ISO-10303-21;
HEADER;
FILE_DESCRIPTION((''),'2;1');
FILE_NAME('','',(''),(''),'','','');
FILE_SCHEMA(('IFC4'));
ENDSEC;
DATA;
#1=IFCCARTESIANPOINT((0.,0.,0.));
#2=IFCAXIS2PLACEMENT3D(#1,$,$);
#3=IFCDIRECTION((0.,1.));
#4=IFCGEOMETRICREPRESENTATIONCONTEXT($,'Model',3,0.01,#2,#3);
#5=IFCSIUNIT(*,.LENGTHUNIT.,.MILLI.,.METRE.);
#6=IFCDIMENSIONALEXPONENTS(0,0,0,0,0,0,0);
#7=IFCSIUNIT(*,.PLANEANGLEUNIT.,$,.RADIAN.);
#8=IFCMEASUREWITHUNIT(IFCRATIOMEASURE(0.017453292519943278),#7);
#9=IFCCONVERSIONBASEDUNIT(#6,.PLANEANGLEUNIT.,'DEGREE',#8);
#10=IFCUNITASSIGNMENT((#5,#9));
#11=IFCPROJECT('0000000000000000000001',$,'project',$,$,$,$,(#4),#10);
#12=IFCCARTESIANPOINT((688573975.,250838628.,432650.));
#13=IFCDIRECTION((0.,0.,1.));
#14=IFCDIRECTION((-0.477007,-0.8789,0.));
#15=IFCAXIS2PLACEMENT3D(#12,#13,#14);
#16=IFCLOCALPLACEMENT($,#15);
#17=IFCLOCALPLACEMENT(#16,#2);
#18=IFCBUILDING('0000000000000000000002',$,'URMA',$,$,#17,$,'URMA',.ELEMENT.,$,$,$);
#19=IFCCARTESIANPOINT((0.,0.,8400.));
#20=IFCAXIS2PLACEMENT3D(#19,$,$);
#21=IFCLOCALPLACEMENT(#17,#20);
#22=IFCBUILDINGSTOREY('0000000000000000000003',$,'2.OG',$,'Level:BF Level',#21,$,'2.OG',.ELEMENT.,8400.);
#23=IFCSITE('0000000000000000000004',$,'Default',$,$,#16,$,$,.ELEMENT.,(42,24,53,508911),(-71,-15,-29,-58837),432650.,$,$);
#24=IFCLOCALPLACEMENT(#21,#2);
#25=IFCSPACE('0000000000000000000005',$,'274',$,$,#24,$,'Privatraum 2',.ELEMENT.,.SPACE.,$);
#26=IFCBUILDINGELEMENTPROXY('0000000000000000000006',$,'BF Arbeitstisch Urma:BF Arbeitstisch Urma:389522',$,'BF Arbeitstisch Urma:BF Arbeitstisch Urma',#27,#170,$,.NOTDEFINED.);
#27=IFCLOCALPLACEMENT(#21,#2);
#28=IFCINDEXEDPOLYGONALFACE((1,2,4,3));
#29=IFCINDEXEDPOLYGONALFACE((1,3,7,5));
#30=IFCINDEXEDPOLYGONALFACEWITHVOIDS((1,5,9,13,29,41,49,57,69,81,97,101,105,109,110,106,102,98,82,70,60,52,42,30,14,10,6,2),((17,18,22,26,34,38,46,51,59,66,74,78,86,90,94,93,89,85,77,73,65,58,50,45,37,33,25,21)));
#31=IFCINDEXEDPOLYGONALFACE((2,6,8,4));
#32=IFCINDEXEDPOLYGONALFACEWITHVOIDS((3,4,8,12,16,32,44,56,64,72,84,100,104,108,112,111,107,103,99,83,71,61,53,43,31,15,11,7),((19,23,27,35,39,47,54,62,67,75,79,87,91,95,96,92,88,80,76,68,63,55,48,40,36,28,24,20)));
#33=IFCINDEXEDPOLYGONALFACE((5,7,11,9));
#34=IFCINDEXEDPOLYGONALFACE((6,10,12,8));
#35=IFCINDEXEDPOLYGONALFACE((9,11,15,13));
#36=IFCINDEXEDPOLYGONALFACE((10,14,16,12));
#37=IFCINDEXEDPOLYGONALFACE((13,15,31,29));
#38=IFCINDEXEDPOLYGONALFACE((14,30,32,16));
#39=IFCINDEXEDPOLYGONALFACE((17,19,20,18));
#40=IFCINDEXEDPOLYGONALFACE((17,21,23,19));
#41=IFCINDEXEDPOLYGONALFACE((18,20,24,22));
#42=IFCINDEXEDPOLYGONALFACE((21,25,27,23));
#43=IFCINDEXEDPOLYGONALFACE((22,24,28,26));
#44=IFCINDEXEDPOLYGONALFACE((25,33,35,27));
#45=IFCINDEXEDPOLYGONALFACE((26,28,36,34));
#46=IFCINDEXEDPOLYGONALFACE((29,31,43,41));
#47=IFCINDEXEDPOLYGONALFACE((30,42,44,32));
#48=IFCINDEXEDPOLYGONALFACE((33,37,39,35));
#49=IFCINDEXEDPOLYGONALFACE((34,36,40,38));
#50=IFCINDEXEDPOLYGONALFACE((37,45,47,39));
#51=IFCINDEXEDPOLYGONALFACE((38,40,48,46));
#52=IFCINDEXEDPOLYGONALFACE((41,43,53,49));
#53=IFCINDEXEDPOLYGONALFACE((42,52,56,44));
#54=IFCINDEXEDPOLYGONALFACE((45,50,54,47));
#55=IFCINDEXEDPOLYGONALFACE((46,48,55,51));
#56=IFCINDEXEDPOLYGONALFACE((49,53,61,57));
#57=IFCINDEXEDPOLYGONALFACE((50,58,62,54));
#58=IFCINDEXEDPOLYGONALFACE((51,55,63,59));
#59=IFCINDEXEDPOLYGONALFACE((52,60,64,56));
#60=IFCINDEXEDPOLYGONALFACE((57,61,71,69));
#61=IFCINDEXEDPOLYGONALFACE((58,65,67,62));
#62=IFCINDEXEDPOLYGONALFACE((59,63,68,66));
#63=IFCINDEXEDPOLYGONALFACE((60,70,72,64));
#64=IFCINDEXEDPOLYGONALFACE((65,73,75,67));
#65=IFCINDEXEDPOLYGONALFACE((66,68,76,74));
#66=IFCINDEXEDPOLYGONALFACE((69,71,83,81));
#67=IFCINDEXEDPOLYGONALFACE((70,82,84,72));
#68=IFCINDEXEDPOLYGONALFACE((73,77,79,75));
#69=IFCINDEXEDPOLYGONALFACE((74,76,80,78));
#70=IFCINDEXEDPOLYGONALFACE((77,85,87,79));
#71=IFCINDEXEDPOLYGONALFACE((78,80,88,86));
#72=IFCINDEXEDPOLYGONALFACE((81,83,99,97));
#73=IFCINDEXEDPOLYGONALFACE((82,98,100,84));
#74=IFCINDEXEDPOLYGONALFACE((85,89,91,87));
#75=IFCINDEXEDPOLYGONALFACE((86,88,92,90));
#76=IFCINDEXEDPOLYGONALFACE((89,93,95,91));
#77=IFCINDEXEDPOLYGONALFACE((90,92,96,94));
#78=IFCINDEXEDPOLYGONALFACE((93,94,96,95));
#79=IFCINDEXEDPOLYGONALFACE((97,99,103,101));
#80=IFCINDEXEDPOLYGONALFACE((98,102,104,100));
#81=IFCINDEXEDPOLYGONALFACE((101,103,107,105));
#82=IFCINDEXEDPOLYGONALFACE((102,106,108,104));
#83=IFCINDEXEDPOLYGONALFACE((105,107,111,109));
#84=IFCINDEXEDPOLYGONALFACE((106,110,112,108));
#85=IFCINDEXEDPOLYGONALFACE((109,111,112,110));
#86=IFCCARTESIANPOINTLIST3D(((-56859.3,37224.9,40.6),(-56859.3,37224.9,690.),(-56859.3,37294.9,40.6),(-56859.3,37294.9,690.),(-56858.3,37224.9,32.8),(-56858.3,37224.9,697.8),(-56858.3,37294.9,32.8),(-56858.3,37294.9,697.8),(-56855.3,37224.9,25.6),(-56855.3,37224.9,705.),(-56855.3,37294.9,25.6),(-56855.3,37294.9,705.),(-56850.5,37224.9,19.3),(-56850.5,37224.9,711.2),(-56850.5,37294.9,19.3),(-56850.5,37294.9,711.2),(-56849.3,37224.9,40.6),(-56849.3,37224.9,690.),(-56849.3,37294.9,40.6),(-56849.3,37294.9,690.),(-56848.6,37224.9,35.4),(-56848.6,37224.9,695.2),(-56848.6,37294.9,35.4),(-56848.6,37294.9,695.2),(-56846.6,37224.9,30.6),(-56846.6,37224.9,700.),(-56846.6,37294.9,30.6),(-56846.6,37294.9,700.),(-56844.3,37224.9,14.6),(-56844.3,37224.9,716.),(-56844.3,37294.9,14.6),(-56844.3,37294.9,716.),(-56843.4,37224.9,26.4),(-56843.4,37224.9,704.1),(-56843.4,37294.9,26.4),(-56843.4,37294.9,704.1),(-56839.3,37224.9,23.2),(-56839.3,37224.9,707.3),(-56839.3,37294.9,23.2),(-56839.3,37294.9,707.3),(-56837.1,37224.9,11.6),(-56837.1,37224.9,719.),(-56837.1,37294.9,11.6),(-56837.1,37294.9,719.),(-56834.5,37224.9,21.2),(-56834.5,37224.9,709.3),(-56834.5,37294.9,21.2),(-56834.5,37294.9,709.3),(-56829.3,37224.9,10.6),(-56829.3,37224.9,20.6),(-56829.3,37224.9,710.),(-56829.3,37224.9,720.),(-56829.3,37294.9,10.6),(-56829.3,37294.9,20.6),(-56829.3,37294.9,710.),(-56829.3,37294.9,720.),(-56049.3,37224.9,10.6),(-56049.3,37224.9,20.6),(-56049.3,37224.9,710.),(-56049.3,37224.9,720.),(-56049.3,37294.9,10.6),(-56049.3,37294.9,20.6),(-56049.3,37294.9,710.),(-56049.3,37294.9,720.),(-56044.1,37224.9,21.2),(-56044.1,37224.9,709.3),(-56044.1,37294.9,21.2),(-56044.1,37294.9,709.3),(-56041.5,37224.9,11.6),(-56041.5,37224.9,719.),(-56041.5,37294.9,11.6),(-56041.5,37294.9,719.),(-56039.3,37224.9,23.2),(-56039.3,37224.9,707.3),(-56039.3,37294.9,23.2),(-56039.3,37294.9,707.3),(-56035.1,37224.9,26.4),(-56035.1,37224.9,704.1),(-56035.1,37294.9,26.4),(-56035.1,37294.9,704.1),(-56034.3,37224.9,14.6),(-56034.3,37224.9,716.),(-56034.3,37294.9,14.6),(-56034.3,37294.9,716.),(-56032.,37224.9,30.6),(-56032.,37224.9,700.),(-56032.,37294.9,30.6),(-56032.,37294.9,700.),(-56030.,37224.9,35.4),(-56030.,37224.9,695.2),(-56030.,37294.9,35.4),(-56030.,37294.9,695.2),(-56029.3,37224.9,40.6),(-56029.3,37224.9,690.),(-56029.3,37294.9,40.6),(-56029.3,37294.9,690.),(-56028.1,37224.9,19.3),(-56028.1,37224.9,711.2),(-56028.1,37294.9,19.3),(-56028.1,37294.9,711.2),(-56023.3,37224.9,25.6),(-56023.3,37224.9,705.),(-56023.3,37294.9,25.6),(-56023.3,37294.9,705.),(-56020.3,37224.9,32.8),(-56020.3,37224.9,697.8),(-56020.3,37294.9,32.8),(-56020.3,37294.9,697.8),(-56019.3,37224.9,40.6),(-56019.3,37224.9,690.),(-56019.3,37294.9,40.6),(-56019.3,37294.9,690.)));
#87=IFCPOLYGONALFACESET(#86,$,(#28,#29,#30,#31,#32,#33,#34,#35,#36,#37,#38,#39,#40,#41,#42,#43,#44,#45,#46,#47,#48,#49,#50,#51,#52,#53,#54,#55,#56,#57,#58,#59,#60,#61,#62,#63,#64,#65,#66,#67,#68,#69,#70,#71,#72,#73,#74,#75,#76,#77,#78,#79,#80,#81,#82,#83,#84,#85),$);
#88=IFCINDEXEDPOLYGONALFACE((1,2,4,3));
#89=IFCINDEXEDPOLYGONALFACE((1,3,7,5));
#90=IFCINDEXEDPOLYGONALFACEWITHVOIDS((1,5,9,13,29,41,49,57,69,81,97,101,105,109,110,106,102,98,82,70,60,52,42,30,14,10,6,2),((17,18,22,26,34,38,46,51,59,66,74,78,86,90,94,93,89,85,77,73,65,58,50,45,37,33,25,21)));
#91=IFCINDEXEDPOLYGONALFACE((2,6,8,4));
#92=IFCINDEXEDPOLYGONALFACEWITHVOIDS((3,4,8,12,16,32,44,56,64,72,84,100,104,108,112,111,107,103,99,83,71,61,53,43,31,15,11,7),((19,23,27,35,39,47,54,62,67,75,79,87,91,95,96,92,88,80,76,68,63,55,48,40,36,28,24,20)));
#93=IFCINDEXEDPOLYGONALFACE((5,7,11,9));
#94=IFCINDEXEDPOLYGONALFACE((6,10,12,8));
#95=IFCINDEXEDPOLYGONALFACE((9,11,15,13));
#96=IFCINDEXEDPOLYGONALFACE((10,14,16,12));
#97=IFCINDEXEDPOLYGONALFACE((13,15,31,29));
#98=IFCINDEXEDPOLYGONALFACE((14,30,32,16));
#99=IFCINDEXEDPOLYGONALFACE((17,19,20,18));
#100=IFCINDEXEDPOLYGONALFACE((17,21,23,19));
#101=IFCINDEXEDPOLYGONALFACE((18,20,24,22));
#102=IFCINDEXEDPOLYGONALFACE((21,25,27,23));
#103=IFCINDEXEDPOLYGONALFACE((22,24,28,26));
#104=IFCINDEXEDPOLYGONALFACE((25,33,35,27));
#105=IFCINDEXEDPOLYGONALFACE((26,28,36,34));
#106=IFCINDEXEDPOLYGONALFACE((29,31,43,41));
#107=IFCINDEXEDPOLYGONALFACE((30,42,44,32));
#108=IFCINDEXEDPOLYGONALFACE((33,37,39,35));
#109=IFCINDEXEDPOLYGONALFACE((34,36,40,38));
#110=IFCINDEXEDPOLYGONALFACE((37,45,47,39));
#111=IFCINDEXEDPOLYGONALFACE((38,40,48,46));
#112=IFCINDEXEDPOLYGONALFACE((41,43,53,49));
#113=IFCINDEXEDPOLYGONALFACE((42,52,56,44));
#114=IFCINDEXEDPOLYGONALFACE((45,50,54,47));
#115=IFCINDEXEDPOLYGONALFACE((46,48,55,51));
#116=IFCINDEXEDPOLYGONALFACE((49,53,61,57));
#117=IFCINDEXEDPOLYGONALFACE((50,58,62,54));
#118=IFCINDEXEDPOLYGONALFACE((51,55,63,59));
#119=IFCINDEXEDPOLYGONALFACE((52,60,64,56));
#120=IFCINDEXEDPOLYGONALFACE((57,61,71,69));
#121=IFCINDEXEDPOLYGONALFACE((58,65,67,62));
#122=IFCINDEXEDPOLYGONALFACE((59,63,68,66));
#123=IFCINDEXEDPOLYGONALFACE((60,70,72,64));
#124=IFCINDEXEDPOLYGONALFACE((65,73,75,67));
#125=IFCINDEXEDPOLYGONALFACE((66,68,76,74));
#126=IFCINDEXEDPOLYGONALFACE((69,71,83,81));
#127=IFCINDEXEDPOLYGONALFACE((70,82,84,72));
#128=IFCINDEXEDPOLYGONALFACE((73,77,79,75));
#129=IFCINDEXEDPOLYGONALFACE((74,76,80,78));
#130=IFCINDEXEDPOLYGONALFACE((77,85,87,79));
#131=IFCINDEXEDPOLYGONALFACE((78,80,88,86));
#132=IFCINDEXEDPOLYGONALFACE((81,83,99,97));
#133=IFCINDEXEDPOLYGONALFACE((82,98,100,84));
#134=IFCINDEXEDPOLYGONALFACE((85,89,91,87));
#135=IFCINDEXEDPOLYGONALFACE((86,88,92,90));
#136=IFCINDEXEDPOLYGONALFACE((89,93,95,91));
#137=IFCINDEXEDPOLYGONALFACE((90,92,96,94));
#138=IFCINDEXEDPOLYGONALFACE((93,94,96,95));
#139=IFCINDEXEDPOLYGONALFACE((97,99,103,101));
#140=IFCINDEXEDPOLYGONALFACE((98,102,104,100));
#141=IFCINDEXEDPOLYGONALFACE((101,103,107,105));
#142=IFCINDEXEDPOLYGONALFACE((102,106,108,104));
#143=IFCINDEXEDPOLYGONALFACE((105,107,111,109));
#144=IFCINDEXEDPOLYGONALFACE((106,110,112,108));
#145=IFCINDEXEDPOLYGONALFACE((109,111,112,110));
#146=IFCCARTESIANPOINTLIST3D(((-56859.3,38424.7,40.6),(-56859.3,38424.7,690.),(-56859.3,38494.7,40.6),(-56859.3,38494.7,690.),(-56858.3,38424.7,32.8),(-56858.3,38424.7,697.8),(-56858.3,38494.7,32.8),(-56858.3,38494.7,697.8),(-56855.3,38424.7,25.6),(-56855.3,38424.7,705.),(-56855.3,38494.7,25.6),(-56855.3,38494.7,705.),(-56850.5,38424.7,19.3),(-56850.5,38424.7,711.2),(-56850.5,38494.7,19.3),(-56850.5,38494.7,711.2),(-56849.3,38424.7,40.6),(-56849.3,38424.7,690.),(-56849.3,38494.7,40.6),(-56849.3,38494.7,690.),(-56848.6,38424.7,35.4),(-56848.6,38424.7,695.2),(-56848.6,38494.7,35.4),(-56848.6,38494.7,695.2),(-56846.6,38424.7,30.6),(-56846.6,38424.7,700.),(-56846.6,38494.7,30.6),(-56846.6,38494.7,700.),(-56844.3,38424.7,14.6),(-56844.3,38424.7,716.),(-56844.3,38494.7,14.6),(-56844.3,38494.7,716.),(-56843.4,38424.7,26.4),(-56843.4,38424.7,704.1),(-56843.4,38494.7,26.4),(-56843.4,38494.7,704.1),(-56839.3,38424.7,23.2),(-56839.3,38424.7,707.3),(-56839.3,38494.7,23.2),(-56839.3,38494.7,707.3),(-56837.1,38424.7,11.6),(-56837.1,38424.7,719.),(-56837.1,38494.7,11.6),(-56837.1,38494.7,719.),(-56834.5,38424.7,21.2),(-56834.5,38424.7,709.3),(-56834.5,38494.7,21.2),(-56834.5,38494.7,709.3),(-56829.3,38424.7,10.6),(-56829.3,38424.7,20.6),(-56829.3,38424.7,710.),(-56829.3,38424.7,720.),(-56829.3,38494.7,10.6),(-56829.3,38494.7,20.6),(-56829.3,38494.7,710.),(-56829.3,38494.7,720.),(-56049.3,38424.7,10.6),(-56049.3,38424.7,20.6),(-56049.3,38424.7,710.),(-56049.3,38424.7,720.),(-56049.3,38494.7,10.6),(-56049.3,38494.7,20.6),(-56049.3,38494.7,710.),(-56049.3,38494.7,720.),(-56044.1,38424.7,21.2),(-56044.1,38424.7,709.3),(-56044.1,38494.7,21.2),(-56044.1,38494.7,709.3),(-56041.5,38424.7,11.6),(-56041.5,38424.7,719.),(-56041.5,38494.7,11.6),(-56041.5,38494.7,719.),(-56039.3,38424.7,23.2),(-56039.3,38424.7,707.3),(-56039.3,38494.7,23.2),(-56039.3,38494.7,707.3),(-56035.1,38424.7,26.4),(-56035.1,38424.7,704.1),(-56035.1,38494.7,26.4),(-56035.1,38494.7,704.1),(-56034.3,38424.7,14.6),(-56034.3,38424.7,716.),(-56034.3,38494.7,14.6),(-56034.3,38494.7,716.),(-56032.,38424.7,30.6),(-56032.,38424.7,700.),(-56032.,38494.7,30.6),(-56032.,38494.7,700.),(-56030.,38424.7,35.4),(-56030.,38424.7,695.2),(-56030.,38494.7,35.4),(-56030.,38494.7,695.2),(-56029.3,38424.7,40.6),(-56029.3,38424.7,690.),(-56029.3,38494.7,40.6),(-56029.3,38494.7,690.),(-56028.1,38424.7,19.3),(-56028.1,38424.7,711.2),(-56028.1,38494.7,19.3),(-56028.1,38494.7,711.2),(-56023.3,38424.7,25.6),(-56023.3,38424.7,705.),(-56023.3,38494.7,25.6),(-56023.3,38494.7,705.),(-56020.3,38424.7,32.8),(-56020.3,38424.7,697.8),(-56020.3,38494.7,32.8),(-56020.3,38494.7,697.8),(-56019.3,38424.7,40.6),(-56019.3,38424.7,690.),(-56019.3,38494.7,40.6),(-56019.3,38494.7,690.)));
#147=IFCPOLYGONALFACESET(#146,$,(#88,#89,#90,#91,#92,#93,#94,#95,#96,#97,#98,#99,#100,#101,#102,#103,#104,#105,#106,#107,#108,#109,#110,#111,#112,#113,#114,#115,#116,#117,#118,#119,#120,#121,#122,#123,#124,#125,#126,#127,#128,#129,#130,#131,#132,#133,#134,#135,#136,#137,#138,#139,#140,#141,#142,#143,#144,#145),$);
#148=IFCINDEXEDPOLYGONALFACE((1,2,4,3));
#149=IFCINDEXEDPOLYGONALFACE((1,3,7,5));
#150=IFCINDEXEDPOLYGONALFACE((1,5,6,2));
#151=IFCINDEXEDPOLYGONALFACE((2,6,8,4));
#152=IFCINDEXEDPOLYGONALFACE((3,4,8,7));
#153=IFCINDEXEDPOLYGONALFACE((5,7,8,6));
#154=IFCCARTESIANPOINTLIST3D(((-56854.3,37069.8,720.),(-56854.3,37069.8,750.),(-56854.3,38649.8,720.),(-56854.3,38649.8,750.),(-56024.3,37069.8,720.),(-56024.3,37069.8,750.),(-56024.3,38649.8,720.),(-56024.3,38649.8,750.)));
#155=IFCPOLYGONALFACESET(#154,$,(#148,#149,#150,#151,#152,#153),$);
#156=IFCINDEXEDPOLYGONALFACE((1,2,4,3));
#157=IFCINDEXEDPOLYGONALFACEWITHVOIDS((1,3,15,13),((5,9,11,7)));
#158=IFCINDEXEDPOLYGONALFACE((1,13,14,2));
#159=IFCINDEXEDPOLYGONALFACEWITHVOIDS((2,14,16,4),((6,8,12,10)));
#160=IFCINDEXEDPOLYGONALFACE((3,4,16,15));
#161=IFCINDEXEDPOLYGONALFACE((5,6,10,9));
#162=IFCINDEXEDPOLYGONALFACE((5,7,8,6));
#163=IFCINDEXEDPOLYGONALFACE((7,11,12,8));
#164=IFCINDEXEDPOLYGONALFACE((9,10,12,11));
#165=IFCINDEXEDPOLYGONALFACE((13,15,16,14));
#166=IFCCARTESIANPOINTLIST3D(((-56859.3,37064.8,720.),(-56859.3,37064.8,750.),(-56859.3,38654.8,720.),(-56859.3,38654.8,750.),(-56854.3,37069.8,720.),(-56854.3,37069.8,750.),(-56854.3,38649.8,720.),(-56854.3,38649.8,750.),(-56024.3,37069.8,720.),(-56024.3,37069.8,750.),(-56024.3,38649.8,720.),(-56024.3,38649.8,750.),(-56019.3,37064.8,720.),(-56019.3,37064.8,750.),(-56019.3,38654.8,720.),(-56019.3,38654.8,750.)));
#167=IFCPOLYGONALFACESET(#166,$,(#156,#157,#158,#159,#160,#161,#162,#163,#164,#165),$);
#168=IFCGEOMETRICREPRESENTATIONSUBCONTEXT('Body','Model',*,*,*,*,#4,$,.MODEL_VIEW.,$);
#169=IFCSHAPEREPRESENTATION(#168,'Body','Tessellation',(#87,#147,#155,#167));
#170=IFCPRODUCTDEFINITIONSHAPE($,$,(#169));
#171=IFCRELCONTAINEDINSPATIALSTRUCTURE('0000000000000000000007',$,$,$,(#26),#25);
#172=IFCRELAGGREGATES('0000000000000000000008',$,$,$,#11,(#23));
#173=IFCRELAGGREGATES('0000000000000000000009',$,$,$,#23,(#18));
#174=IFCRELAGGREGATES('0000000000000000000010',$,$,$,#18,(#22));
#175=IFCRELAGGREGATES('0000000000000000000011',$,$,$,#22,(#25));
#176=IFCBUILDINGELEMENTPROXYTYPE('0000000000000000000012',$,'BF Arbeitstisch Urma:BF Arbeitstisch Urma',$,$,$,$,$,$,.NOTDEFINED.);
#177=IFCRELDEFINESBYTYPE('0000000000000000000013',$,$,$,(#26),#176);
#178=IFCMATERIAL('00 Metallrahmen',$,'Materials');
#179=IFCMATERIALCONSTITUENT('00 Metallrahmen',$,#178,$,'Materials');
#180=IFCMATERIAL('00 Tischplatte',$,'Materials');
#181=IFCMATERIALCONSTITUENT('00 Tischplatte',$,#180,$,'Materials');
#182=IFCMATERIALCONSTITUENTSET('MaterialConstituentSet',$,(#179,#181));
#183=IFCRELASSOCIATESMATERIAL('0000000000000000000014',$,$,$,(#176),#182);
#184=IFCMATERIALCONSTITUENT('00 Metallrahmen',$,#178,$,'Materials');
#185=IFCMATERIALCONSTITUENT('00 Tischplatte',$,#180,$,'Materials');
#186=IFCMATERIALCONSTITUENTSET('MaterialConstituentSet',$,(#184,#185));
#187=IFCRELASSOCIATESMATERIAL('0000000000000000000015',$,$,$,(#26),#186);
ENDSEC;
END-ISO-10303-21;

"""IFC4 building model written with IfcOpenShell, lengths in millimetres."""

from ifc_helpers import new_model, entity, si_unit, converted_unit, direction, frame, origin, place, context, subcontext, project, spatial, line, arc, indexed_curve, outline, extrude, source, transform, mapped, material, constituent, constituent_set, type_object, type_shapes, element, save


model = new_model("IFC4")

# Units and contexts
model_context = context("Model", 3, precision=0.01, world=origin(), true_north=direction((0.0, 1.0)))
body_context = subcontext(model_context, "Body", "Model", "MODEL_VIEW")
ifc_project = project(units=[si_unit("LENGTHUNIT", "METRE", prefix="MILLI"), converted_unit("PLANEANGLEUNIT", "DEGREE", entity("IfcRatioMeasure", 0.017453292519943278), si_unit("PLANEANGLEUNIT", "RADIAN"), dimensions=[0, 0, 0, 0, 0, 0, 0])], contexts=[model_context])

# Site, building, storey
site_placement = place(None, frame((688573975.0, 250838628.0, 432650.0), z_axis=(0.0, 0.0, 1.0), x_axis=(-0.477007, -0.8789, 0.0)))
site = spatial("IfcSite", under=ifc_project, at=site_placement, Name="Default", CompositionType="ELEMENT", RefLatitude=(42, 24, 53, 508911), RefLongitude=(-71, -15, -29, -58837), RefElevation=432650.0)
building_placement = place(site_placement, origin())
building = spatial("IfcBuilding", under=site, at=building_placement, Name="URMA", LongName="URMA", CompositionType="ELEMENT")
storey_placement = place(building_placement, frame((0.0, 0.0, 8400.0)))
storey = spatial("IfcBuildingStorey", under=building, at=storey_placement, Name="2.OG", ObjectType="Level:BF Level", LongName="2.OG", CompositionType="ELEMENT", Elevation=8400.0)

# Shared definitions
ifc_material_1 = material(Name="00 Metallrahmen", Category="Materials")

# Shared definitions
ifc_material_2 = material(Name="00 Tischplatte", Category="Materials")
ifc_constituent_1 = constituent(ifc_material_1, Name="00 Metallrahmen", Category="Materials")
ifc_constituent_2 = constituent(ifc_material_2, Name="00 Tischplatte", Category="Materials")
ifc_constituent_set_1 = constituent_set(constituents=[ifc_constituent_1, ifc_constituent_2], Name="MaterialConstituentSet")
building_element_proxy_type_1 = type_object("IfcBuildingElementProxyType", Name="BF Arbeitstisch Urma:BF Arbeitstisch Urma", PredefinedType="NOTDEFINED", material=ifc_constituent_set_1)
shared_shape_1 = source(origin(), body_context, "Body", "SweptSolid", [
    extrude(outline(indexed_curve([(-390.0, -354.7), (390.0, -354.7), (411.2, -345.9), (420.0, -324.7), (420.0, 324.7), (411.2, 345.9), (390.0, 354.7), (-390.0, 354.7), (-411.2, 345.9), (-420.0, 324.7), (-420.0, -324.7), (-411.2, -345.9)], segments=[line(1, 2), arc(2, 3, 4), line(4, 5), arc(5, 6, 7), line(7, 8), arc(8, 9, 10), line(10, 11), arc(11, 12, 1)], self_intersect=False), holes=[indexed_curve([(410.0, 324.7), (410.0, -324.7), (404.1, -338.9), (390.0, -344.7), (-390.0, -344.7), (-404.1, -338.9), (-410.0, -324.7), (-410.0, 324.7), (-404.1, 338.9), (-390.0, 344.7), (390.0, 344.7), (404.1, 338.9)], segments=[line(1, 2), arc(2, 3, 4), line(4, 5), arc(5, 6, 7), line(7, 8), arc(8, 9, 10), line(10, 11), arc(11, 12, 1)], self_intersect=False)]), frame((-634.4, -4.8, 365.3), z_axis=(1.0, 0.0, 0.0), x_axis=(0.0, -1.0, 0.0)), (0.0, 0.0, 1.0), 70.0),
    extrude(outline(indexed_curve([(-390.0, -354.7), (390.0, -354.7), (411.2, -345.9), (420.0, -324.7), (420.0, 324.7), (411.2, 345.9), (390.0, 354.7), (-390.0, 354.7), (-411.2, 345.9), (-420.0, 324.7), (-420.0, -324.7), (-411.2, -345.9)], segments=[line(1, 2), arc(2, 3, 4), line(4, 5), arc(5, 6, 7), line(7, 8), arc(8, 9, 10), line(10, 11), arc(11, 12, 1)], self_intersect=False), holes=[indexed_curve([(410.0, 324.7), (410.0, -324.7), (404.1, -338.9), (390.0, -344.7), (-390.0, -344.7), (-404.1, -338.9), (-410.0, -324.7), (-410.0, 324.7), (-404.1, 338.9), (-390.0, 344.7), (390.0, 344.7), (404.1, 338.9)], segments=[line(1, 2), arc(2, 3, 4), line(4, 5), arc(5, 6, 7), line(7, 8), arc(8, 9, 10), line(10, 11), arc(11, 12, 1)], self_intersect=False)]), frame((565.4, -4.8, 365.3), z_axis=(1.0, 0.0, 0.0), x_axis=(0.0, -1.0, 0.0)), (0.0, 0.0, 1.0), 70.0),
    extrude(outline(indexed_curve([(-790.0, -415.0), (790.0, -415.0), (790.0, 415.0), (-790.0, 415.0), (-790.0, -415.0)], self_intersect=False)), frame((0.5, -4.8, 720.0), z_axis=(0.0, 0.0, 1.0), x_axis=(-1.0, 0.0, 0.0)), (0.0, 0.0, 1.0), 30.0),
    extrude(outline(indexed_curve([(-795.0, -420.0), (795.0, -420.0), (795.0, 420.0), (-795.0, 420.0), (-795.0, -420.0)], self_intersect=False), holes=[indexed_curve([(790.0, 415.0), (790.0, -415.0), (-790.0, -415.0), (-790.0, 415.0), (790.0, 415.0)], self_intersect=False)]), frame((0.5, -4.8, 720.0)), (0.0, 0.0, 1.0), 30.0),
])
type_shapes(building_element_proxy_type_1, [shared_shape_1])

# Shared definitions
space_1_placement = place(storey_placement, origin())
space_1 = spatial("IfcSpace", under=storey, at=space_1_placement, Name="274", LongName="Privatraum 2", CompositionType="ELEMENT", PredefinedType="SPACE")

# Building element proxy
ifc_constituent_3 = constituent(ifc_material_1, Name="00 Metallrahmen", Category="Materials")
ifc_constituent_4 = constituent(ifc_material_2, Name="00 Tischplatte", Category="Materials")
ifc_constituent_set_2 = constituent_set(constituents=[ifc_constituent_3, ifc_constituent_4], Name="MaterialConstituentSet")
proxy_1_placement = place(space_1_placement, frame((-56444.1, 37859.3, 0.0), z_axis=(0.0, 0.0, 1.0), x_axis=(0.0, 1.0, 0.0)))
element("IfcBuildingElementProxy", 1, at=proxy_1_placement, inside=space_1, type_object=building_element_proxy_type_1, material=ifc_constituent_set_2, Name="BF Arbeitstisch Urma:BF Arbeitstisch Urma:389522", ObjectType="BF Arbeitstisch Urma:BF Arbeitstisch Urma", PredefinedType="NOTDEFINED", context=body_context, shape_type="MappedRepresentation", body=[
    mapped(shared_shape_1, transform((0.0, 0.0, 0.0), scale=1.0)),
])

save(model, "model.ifc")
